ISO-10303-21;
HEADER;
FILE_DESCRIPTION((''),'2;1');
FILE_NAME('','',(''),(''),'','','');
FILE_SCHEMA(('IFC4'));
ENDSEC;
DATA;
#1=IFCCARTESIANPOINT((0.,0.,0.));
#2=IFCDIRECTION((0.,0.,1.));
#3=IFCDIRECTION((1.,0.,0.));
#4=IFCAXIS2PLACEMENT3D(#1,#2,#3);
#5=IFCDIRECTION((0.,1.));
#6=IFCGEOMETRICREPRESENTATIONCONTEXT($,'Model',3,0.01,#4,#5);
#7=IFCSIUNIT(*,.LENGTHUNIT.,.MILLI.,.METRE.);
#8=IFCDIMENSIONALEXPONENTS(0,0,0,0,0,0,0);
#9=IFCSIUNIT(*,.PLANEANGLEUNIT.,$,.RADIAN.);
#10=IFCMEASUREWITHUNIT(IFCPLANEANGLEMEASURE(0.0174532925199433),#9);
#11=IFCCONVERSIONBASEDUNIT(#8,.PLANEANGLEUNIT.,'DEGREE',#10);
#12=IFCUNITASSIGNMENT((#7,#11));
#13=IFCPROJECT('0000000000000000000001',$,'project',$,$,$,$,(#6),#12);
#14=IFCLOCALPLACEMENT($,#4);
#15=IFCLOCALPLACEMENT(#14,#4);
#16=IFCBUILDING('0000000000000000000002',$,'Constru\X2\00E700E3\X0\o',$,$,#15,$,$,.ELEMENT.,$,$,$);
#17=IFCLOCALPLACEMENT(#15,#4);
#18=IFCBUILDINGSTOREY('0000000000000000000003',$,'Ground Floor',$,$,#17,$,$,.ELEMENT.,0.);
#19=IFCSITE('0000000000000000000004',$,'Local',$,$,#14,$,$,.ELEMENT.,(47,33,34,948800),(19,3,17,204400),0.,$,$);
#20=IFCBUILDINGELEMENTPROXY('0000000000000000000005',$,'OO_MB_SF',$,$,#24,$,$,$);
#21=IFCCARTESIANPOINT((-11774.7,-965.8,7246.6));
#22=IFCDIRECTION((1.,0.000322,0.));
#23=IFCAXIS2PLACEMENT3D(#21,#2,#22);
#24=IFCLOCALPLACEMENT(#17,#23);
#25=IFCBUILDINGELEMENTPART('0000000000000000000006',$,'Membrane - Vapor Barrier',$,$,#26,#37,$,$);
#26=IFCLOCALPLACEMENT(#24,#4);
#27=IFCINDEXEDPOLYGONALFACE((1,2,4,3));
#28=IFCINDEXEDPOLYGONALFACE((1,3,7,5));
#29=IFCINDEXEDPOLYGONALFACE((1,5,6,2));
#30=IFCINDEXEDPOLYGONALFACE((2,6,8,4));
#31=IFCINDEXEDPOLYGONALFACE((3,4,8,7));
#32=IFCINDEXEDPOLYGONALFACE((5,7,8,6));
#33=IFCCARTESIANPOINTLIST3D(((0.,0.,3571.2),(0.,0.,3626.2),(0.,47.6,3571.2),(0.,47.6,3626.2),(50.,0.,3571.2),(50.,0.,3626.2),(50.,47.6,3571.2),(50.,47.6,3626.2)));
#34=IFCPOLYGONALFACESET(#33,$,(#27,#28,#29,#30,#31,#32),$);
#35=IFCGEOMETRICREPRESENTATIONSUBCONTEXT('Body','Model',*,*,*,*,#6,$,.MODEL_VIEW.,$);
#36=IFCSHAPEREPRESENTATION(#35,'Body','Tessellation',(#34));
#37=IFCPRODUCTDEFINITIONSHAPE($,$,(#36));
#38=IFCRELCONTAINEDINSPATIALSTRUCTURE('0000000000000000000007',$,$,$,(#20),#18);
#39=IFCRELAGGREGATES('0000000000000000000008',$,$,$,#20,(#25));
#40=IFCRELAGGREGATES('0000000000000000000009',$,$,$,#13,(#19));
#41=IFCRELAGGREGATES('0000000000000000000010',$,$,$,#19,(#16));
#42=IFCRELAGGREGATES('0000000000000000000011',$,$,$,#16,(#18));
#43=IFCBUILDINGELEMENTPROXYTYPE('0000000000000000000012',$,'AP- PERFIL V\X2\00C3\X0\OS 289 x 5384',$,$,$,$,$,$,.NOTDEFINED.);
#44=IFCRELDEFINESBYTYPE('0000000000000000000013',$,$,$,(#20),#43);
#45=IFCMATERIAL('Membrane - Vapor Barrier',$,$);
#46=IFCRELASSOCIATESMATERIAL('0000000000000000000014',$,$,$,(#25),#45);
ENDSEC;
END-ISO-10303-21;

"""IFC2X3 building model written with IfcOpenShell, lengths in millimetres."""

from ifc_helpers import new_model, entity, si_unit, converted_unit, direction, frame, origin_with_axes, place, context, subcontext, project, spatial, polyline, outline, extrude, material, type_object, element, aggregate, save


model = new_model("IFC2X3")

# Units and contexts
model_context = context("Model", 3, precision=0.01, world=origin_with_axes(), true_north=direction((0.0, 1.0)))
body_context = subcontext(model_context, "Body", "Model", "MODEL_VIEW")
ifc_project = project(units=[si_unit("LENGTHUNIT", "METRE", prefix="MILLI"), converted_unit("PLANEANGLEUNIT", "DEGREE", entity("IfcPlaneAngleMeasure", 0.0174532925199433), si_unit("PLANEANGLEUNIT", "RADIAN"), dimensions=[0, 0, 0, 0, 0, 0, 0])], contexts=[model_context])

# Site, building, storey
site_placement = place(None, origin_with_axes())
site = spatial("IfcSite", under=ifc_project, at=site_placement, Name="Local", CompositionType="ELEMENT", RefLatitude=(47, 33, 34, 948800), RefLongitude=(19, 3, 17, 204400), RefElevation=0.0)
building_placement = place(site_placement, origin_with_axes())
building = spatial("IfcBuilding", under=site, at=building_placement, Name="Construção", CompositionType="ELEMENT")
storey_placement = place(building_placement, origin_with_axes())
storey = spatial("IfcBuildingStorey", under=building, at=storey_placement, Name="Ground Floor", CompositionType="ELEMENT", Elevation=0.0)

# Shared definitions
ifc_material = material(Name="Membrane - Vapor Barrier")

# Building element proxy, building element part
building_element_proxy_type = type_object("IfcBuildingElementProxyType", Name="AP- PERFIL VÃOS 289 x 5384", PredefinedType="NOTDEFINED")
proxy_1_placement = place(storey_placement, frame((-11774.7, -965.8, 7246.6), z_axis=(0.0, 0.0, 1.0), x_axis=(1.0, 0.000322, 0.0)))
proxy_1 = element("IfcBuildingElementProxy", 1, at=proxy_1_placement, inside=storey, type_object=building_element_proxy_type, Name="OO_MB_SF")
building_element_part_1_placement = place(proxy_1_placement, origin_with_axes())
building_element_part_1 = element("IfcBuildingElementPart", 2, at=building_element_part_1_placement, material=ifc_material, Name="Membrane - Vapor Barrier", context=body_context, shape_type="SweptSolid", body=[
    extrude(outline(polyline([(0.0, 3571.2), (50.0, 3571.2), (50.0, 3626.2), (0.0, 3626.2), (0.0, 3571.2)])), frame((0.0, 47.6, 0.0), z_axis=(0.0, -1.0, 0.0), x_axis=(1.0, 0.0, 0.0)), (0.0, 0.0, 1.0), 47.6),
])
aggregate(proxy_1, [building_element_part_1])

save(model, "model.ifc")
